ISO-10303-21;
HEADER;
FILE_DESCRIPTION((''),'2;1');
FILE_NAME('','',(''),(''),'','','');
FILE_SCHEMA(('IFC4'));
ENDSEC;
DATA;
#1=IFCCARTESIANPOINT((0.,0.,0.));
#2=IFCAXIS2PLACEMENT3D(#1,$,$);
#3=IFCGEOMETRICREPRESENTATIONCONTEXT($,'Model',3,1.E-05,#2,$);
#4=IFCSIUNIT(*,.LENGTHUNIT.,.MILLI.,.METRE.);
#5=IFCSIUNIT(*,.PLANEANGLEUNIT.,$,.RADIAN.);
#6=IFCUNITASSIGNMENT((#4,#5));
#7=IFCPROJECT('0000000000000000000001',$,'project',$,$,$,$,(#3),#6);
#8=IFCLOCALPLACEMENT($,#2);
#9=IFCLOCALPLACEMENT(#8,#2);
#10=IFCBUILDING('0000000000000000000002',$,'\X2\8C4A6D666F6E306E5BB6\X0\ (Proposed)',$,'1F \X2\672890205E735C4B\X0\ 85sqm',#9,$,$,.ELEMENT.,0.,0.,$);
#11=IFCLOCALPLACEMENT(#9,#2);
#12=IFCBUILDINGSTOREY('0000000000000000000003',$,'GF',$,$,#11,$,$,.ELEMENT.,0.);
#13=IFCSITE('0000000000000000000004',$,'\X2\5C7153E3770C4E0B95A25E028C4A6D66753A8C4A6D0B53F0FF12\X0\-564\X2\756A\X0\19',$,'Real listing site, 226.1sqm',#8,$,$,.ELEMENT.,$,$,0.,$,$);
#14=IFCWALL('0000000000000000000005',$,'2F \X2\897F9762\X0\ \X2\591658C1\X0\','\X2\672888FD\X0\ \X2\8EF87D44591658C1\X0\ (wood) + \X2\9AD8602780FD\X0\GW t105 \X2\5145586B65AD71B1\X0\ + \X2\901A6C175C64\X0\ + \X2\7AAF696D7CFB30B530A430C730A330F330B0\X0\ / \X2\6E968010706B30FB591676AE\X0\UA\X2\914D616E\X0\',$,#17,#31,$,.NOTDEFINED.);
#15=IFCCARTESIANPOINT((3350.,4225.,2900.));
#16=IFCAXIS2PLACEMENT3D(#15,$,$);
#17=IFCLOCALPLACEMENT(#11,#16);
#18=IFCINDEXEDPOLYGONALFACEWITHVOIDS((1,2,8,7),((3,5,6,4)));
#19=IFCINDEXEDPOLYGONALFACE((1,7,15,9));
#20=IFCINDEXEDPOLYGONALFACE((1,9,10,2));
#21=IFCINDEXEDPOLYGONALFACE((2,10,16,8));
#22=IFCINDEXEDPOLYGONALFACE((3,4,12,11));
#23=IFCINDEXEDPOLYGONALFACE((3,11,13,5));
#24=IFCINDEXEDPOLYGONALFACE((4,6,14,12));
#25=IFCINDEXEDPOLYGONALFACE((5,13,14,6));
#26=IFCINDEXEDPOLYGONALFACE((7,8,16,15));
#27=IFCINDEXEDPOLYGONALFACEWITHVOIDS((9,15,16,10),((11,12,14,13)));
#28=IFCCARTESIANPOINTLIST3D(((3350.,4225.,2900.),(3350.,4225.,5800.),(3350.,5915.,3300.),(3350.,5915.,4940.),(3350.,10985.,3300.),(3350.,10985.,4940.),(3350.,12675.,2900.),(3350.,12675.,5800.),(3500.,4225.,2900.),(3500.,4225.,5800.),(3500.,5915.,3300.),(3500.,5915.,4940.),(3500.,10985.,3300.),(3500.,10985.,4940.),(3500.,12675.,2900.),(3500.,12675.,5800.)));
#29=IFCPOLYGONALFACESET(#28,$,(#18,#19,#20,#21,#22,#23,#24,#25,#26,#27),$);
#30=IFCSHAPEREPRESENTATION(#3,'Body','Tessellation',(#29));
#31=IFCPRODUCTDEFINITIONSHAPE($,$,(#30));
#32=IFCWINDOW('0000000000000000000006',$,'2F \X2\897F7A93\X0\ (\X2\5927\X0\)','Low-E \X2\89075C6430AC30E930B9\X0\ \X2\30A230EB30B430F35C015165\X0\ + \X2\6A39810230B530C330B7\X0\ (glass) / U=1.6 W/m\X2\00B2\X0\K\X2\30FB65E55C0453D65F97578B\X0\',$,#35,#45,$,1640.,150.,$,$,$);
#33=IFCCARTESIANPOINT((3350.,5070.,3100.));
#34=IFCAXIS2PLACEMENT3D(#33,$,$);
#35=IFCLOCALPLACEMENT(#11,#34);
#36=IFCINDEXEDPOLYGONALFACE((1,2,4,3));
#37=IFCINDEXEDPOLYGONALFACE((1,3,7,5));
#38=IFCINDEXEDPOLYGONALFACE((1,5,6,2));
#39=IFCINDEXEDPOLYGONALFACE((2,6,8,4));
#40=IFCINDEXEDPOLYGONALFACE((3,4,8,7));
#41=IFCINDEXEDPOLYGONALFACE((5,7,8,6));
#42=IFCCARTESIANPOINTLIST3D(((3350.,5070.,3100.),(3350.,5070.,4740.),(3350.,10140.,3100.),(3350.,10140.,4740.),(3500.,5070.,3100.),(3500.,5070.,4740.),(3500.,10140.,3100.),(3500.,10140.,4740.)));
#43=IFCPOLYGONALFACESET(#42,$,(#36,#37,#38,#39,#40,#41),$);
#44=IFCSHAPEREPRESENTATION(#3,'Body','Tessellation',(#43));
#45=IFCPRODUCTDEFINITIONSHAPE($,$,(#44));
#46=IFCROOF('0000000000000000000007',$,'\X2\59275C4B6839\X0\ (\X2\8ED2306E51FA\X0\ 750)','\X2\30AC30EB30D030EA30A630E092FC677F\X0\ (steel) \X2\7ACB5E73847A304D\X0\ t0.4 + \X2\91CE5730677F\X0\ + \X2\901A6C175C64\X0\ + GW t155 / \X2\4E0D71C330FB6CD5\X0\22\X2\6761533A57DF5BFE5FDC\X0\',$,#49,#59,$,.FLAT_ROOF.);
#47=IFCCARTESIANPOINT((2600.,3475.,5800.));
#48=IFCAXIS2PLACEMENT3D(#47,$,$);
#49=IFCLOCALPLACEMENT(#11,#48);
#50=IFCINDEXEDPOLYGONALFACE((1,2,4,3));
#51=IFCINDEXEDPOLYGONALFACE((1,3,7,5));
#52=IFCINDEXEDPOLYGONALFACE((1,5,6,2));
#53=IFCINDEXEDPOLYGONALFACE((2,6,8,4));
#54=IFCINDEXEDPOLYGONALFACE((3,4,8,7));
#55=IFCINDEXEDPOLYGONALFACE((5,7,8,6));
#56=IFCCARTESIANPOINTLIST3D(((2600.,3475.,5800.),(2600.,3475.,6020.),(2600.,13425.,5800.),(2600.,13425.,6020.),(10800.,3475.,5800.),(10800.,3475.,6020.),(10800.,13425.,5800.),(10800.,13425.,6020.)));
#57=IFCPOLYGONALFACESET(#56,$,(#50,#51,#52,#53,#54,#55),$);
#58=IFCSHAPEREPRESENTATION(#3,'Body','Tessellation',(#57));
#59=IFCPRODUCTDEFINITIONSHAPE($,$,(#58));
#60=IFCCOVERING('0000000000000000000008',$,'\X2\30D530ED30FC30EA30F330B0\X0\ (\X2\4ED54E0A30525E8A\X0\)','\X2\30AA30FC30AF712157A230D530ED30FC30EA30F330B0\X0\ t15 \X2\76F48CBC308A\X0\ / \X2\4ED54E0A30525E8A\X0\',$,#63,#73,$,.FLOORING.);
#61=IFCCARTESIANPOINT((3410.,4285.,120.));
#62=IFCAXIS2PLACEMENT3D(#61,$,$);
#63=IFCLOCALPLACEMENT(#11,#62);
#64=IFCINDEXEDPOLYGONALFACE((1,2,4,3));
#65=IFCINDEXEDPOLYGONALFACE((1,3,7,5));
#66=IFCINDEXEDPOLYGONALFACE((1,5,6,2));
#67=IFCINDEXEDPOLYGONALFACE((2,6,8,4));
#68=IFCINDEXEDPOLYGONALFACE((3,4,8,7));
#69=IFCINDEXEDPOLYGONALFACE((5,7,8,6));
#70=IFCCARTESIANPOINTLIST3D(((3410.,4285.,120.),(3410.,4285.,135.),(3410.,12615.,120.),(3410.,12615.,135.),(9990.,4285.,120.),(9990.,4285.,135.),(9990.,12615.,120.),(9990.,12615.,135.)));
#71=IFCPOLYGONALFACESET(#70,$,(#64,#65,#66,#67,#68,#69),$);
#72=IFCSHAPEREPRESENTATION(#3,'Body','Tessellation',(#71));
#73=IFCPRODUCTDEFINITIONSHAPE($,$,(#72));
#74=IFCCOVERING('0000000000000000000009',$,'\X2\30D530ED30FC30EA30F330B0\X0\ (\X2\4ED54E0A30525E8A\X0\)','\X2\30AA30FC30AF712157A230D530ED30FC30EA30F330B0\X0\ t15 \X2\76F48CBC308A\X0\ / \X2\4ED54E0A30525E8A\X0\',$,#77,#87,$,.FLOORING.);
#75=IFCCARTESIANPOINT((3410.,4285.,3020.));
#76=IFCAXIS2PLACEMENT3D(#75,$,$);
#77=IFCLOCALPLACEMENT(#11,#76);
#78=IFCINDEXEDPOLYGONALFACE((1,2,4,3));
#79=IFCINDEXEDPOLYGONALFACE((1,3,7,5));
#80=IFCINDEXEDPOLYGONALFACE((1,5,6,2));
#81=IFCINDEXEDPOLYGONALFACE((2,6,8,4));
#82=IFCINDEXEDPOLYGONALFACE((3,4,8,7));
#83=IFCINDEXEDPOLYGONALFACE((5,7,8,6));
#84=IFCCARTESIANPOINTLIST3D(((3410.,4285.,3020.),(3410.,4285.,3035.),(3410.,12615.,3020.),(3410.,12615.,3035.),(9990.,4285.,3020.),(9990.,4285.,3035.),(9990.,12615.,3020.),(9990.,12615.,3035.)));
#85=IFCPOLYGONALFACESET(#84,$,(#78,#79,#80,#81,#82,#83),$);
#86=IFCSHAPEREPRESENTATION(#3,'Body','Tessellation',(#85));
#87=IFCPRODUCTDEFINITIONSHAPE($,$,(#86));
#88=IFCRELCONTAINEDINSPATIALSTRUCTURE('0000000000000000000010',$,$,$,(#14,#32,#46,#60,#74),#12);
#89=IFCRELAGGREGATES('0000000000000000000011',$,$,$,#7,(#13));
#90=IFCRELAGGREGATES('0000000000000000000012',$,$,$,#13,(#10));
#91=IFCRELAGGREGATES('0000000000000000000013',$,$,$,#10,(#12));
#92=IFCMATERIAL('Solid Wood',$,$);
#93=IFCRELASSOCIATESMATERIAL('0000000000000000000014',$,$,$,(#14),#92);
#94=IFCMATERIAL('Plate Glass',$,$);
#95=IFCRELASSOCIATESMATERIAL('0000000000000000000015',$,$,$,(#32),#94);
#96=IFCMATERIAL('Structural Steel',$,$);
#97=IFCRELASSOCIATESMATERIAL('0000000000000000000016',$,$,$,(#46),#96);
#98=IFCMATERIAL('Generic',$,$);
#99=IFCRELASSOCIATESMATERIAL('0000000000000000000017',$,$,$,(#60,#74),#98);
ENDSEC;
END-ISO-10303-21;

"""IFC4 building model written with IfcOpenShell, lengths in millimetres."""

from ifc_helpers import new_model, si_unit, frame, frame_2d, origin, place, context, project, spatial, rectangle, extrude, material, element, fill, save


model = new_model("IFC4")

# Units and contexts
model_context = context("Model", 3, precision=1e-05, world=origin())
ifc_project = project(units=[si_unit("LENGTHUNIT", "METRE", prefix="MILLI"), si_unit("PLANEANGLEUNIT", "RADIAN")], contexts=[model_context])

# Site, building, storey
site_placement = place(None, origin())
site = spatial("IfcSite", under=ifc_project, at=site_placement, Name="山口県下関市豊浦町豊洋台２-564番19", ObjectType="Real listing site, 226.1sqm", CompositionType="ELEMENT", RefElevation=0.0)
building_placement = place(site_placement, origin())
building = spatial("IfcBuilding", under=site, at=building_placement, Name="豊浦潮の家 (Proposed)", ObjectType="1F 木造平屋 85sqm", CompositionType="ELEMENT", ElevationOfRefHeight=0.0, ElevationOfTerrain=0.0)
storey_placement = place(building_placement, origin())
storey = spatial("IfcBuildingStorey", under=building, at=storey_placement, Name="GF", CompositionType="ELEMENT", Elevation=0.0)

# Shared definitions
ifc_material_1 = material(Name="Solid Wood")
ifc_material_2 = material(Name="Generic")

# Shared definitions
ifc_material_3 = material(Name="Plate Glass")

# Wall, opening, window
wall_1_placement = place(storey_placement, frame((3350.0, 4225.0, 2900.0)))
wall_1 = element("IfcWall", 1, at=wall_1_placement, inside=storey, material=ifc_material_1, Name="2F 西面 外壁", Description="木製 軸組外壁 (wood) + 高性能GW t105 充填断熱 + 通気層 + 窯業系サイディング / 準耐火・外皮UA配慮", PredefinedType="NOTDEFINED", context=model_context, shape_type="SweptSolid", body=[
    extrude(rectangle(XDim=150.0, YDim=8450.0, at=frame_2d((75.0, 4225.0))), frame((3350.0, 4225.0, 2900.0)), (0.0, 0.0, 1.0), 2900.0),
])
opening_1_placement = place(storey_placement, frame((3350.0, 5070.0, 3100.0)))
opening_1 = element("IfcOpeningElement", 2, at=opening_1_placement, cuts=wall_1, PredefinedType="NOTDEFINED", context=model_context, shape_type="SweptSolid", body=[
    extrude(rectangle(XDim=150.0, YDim=5070.0, at=frame_2d((75.0, 2535.0))), frame((3350.0, 5070.0, 3100.0)), (0.0, 0.0, 1.0), 1640.0),
])
window_1_placement = place(storey_placement, frame((3350.0, 5070.0, 3100.0)))
window_1 = element("IfcWindow", 3, at=window_1_placement, inside=storey, material=ifc_material_3, Name="2F 西窓 (大)", Description="Low-E 複層ガラス アルゴン封入 + 樹脂サッシ (glass) / U=1.6 W/m²K・日射取得型", OverallHeight=1640.0, OverallWidth=150.0, context=model_context, shape_type="SweptSolid", body=[
    extrude(rectangle(XDim=150.0, YDim=5070.0, at=frame_2d((75.0, 2535.0))), frame((3350.0, 5070.0, 3100.0)), (0.0, 0.0, 1.0), 1640.0),
])
fill(opening_1, window_1)

# Roof
ifc_material_4 = material(Name="Structural Steel")
roof_placement = place(storey_placement, frame((2600.0, 3475.0, 5800.0)))
element("IfcRoof", 4, at=roof_placement, inside=storey, material=ifc_material_4, Name="大屋根 (軒の出 750)", Description="ガルバリウム鋼板 (steel) 立平葺き t0.4 + 野地板 + 通気層 + GW t155 / 不燃・法22条区域対応", PredefinedType="FLAT_ROOF", context=model_context, shape_type="SweptSolid", body=[
    extrude(rectangle(XDim=8200.0, YDim=9950.0, at=frame_2d((4100.0, 4975.0))), frame((2600.0, 3475.0, 5800.0)), (0.0, 0.0, 1.0), 220.0),
])

# Coverings
covering_1_placement = place(storey_placement, frame((3410.0, 4285.0, 120.0)))
element("IfcCovering", 5, at=covering_1_placement, inside=storey, material=ifc_material_2, Name="フローリング (仕上げ床)", Description="オーク無垢フローリング t15 直貼り / 仕上げ床", PredefinedType="FLOORING", context=model_context, shape_type="SweptSolid", body=[
    extrude(rectangle(XDim=6580.0, YDim=8330.0, at=frame_2d((3290.0, 4165.0))), frame((3410.0, 4285.0, 120.0)), (0.0, 0.0, 1.0), 15.0),
])
covering_2_placement = place(storey_placement, frame((3410.0, 4285.0, 3020.0)))
element("IfcCovering", 6, at=covering_2_placement, inside=storey, material=ifc_material_2, Name="フローリング (仕上げ床)", Description="オーク無垢フローリング t15 直貼り / 仕上げ床", PredefinedType="FLOORING", context=model_context, shape_type="SweptSolid", body=[
    extrude(rectangle(XDim=6580.0, YDim=8330.0, at=frame_2d((3290.0, 4165.0))), frame((3410.0, 4285.0, 3020.0)), (0.0, 0.0, 1.0), 15.0),
])

save(model, "model.ifc")
